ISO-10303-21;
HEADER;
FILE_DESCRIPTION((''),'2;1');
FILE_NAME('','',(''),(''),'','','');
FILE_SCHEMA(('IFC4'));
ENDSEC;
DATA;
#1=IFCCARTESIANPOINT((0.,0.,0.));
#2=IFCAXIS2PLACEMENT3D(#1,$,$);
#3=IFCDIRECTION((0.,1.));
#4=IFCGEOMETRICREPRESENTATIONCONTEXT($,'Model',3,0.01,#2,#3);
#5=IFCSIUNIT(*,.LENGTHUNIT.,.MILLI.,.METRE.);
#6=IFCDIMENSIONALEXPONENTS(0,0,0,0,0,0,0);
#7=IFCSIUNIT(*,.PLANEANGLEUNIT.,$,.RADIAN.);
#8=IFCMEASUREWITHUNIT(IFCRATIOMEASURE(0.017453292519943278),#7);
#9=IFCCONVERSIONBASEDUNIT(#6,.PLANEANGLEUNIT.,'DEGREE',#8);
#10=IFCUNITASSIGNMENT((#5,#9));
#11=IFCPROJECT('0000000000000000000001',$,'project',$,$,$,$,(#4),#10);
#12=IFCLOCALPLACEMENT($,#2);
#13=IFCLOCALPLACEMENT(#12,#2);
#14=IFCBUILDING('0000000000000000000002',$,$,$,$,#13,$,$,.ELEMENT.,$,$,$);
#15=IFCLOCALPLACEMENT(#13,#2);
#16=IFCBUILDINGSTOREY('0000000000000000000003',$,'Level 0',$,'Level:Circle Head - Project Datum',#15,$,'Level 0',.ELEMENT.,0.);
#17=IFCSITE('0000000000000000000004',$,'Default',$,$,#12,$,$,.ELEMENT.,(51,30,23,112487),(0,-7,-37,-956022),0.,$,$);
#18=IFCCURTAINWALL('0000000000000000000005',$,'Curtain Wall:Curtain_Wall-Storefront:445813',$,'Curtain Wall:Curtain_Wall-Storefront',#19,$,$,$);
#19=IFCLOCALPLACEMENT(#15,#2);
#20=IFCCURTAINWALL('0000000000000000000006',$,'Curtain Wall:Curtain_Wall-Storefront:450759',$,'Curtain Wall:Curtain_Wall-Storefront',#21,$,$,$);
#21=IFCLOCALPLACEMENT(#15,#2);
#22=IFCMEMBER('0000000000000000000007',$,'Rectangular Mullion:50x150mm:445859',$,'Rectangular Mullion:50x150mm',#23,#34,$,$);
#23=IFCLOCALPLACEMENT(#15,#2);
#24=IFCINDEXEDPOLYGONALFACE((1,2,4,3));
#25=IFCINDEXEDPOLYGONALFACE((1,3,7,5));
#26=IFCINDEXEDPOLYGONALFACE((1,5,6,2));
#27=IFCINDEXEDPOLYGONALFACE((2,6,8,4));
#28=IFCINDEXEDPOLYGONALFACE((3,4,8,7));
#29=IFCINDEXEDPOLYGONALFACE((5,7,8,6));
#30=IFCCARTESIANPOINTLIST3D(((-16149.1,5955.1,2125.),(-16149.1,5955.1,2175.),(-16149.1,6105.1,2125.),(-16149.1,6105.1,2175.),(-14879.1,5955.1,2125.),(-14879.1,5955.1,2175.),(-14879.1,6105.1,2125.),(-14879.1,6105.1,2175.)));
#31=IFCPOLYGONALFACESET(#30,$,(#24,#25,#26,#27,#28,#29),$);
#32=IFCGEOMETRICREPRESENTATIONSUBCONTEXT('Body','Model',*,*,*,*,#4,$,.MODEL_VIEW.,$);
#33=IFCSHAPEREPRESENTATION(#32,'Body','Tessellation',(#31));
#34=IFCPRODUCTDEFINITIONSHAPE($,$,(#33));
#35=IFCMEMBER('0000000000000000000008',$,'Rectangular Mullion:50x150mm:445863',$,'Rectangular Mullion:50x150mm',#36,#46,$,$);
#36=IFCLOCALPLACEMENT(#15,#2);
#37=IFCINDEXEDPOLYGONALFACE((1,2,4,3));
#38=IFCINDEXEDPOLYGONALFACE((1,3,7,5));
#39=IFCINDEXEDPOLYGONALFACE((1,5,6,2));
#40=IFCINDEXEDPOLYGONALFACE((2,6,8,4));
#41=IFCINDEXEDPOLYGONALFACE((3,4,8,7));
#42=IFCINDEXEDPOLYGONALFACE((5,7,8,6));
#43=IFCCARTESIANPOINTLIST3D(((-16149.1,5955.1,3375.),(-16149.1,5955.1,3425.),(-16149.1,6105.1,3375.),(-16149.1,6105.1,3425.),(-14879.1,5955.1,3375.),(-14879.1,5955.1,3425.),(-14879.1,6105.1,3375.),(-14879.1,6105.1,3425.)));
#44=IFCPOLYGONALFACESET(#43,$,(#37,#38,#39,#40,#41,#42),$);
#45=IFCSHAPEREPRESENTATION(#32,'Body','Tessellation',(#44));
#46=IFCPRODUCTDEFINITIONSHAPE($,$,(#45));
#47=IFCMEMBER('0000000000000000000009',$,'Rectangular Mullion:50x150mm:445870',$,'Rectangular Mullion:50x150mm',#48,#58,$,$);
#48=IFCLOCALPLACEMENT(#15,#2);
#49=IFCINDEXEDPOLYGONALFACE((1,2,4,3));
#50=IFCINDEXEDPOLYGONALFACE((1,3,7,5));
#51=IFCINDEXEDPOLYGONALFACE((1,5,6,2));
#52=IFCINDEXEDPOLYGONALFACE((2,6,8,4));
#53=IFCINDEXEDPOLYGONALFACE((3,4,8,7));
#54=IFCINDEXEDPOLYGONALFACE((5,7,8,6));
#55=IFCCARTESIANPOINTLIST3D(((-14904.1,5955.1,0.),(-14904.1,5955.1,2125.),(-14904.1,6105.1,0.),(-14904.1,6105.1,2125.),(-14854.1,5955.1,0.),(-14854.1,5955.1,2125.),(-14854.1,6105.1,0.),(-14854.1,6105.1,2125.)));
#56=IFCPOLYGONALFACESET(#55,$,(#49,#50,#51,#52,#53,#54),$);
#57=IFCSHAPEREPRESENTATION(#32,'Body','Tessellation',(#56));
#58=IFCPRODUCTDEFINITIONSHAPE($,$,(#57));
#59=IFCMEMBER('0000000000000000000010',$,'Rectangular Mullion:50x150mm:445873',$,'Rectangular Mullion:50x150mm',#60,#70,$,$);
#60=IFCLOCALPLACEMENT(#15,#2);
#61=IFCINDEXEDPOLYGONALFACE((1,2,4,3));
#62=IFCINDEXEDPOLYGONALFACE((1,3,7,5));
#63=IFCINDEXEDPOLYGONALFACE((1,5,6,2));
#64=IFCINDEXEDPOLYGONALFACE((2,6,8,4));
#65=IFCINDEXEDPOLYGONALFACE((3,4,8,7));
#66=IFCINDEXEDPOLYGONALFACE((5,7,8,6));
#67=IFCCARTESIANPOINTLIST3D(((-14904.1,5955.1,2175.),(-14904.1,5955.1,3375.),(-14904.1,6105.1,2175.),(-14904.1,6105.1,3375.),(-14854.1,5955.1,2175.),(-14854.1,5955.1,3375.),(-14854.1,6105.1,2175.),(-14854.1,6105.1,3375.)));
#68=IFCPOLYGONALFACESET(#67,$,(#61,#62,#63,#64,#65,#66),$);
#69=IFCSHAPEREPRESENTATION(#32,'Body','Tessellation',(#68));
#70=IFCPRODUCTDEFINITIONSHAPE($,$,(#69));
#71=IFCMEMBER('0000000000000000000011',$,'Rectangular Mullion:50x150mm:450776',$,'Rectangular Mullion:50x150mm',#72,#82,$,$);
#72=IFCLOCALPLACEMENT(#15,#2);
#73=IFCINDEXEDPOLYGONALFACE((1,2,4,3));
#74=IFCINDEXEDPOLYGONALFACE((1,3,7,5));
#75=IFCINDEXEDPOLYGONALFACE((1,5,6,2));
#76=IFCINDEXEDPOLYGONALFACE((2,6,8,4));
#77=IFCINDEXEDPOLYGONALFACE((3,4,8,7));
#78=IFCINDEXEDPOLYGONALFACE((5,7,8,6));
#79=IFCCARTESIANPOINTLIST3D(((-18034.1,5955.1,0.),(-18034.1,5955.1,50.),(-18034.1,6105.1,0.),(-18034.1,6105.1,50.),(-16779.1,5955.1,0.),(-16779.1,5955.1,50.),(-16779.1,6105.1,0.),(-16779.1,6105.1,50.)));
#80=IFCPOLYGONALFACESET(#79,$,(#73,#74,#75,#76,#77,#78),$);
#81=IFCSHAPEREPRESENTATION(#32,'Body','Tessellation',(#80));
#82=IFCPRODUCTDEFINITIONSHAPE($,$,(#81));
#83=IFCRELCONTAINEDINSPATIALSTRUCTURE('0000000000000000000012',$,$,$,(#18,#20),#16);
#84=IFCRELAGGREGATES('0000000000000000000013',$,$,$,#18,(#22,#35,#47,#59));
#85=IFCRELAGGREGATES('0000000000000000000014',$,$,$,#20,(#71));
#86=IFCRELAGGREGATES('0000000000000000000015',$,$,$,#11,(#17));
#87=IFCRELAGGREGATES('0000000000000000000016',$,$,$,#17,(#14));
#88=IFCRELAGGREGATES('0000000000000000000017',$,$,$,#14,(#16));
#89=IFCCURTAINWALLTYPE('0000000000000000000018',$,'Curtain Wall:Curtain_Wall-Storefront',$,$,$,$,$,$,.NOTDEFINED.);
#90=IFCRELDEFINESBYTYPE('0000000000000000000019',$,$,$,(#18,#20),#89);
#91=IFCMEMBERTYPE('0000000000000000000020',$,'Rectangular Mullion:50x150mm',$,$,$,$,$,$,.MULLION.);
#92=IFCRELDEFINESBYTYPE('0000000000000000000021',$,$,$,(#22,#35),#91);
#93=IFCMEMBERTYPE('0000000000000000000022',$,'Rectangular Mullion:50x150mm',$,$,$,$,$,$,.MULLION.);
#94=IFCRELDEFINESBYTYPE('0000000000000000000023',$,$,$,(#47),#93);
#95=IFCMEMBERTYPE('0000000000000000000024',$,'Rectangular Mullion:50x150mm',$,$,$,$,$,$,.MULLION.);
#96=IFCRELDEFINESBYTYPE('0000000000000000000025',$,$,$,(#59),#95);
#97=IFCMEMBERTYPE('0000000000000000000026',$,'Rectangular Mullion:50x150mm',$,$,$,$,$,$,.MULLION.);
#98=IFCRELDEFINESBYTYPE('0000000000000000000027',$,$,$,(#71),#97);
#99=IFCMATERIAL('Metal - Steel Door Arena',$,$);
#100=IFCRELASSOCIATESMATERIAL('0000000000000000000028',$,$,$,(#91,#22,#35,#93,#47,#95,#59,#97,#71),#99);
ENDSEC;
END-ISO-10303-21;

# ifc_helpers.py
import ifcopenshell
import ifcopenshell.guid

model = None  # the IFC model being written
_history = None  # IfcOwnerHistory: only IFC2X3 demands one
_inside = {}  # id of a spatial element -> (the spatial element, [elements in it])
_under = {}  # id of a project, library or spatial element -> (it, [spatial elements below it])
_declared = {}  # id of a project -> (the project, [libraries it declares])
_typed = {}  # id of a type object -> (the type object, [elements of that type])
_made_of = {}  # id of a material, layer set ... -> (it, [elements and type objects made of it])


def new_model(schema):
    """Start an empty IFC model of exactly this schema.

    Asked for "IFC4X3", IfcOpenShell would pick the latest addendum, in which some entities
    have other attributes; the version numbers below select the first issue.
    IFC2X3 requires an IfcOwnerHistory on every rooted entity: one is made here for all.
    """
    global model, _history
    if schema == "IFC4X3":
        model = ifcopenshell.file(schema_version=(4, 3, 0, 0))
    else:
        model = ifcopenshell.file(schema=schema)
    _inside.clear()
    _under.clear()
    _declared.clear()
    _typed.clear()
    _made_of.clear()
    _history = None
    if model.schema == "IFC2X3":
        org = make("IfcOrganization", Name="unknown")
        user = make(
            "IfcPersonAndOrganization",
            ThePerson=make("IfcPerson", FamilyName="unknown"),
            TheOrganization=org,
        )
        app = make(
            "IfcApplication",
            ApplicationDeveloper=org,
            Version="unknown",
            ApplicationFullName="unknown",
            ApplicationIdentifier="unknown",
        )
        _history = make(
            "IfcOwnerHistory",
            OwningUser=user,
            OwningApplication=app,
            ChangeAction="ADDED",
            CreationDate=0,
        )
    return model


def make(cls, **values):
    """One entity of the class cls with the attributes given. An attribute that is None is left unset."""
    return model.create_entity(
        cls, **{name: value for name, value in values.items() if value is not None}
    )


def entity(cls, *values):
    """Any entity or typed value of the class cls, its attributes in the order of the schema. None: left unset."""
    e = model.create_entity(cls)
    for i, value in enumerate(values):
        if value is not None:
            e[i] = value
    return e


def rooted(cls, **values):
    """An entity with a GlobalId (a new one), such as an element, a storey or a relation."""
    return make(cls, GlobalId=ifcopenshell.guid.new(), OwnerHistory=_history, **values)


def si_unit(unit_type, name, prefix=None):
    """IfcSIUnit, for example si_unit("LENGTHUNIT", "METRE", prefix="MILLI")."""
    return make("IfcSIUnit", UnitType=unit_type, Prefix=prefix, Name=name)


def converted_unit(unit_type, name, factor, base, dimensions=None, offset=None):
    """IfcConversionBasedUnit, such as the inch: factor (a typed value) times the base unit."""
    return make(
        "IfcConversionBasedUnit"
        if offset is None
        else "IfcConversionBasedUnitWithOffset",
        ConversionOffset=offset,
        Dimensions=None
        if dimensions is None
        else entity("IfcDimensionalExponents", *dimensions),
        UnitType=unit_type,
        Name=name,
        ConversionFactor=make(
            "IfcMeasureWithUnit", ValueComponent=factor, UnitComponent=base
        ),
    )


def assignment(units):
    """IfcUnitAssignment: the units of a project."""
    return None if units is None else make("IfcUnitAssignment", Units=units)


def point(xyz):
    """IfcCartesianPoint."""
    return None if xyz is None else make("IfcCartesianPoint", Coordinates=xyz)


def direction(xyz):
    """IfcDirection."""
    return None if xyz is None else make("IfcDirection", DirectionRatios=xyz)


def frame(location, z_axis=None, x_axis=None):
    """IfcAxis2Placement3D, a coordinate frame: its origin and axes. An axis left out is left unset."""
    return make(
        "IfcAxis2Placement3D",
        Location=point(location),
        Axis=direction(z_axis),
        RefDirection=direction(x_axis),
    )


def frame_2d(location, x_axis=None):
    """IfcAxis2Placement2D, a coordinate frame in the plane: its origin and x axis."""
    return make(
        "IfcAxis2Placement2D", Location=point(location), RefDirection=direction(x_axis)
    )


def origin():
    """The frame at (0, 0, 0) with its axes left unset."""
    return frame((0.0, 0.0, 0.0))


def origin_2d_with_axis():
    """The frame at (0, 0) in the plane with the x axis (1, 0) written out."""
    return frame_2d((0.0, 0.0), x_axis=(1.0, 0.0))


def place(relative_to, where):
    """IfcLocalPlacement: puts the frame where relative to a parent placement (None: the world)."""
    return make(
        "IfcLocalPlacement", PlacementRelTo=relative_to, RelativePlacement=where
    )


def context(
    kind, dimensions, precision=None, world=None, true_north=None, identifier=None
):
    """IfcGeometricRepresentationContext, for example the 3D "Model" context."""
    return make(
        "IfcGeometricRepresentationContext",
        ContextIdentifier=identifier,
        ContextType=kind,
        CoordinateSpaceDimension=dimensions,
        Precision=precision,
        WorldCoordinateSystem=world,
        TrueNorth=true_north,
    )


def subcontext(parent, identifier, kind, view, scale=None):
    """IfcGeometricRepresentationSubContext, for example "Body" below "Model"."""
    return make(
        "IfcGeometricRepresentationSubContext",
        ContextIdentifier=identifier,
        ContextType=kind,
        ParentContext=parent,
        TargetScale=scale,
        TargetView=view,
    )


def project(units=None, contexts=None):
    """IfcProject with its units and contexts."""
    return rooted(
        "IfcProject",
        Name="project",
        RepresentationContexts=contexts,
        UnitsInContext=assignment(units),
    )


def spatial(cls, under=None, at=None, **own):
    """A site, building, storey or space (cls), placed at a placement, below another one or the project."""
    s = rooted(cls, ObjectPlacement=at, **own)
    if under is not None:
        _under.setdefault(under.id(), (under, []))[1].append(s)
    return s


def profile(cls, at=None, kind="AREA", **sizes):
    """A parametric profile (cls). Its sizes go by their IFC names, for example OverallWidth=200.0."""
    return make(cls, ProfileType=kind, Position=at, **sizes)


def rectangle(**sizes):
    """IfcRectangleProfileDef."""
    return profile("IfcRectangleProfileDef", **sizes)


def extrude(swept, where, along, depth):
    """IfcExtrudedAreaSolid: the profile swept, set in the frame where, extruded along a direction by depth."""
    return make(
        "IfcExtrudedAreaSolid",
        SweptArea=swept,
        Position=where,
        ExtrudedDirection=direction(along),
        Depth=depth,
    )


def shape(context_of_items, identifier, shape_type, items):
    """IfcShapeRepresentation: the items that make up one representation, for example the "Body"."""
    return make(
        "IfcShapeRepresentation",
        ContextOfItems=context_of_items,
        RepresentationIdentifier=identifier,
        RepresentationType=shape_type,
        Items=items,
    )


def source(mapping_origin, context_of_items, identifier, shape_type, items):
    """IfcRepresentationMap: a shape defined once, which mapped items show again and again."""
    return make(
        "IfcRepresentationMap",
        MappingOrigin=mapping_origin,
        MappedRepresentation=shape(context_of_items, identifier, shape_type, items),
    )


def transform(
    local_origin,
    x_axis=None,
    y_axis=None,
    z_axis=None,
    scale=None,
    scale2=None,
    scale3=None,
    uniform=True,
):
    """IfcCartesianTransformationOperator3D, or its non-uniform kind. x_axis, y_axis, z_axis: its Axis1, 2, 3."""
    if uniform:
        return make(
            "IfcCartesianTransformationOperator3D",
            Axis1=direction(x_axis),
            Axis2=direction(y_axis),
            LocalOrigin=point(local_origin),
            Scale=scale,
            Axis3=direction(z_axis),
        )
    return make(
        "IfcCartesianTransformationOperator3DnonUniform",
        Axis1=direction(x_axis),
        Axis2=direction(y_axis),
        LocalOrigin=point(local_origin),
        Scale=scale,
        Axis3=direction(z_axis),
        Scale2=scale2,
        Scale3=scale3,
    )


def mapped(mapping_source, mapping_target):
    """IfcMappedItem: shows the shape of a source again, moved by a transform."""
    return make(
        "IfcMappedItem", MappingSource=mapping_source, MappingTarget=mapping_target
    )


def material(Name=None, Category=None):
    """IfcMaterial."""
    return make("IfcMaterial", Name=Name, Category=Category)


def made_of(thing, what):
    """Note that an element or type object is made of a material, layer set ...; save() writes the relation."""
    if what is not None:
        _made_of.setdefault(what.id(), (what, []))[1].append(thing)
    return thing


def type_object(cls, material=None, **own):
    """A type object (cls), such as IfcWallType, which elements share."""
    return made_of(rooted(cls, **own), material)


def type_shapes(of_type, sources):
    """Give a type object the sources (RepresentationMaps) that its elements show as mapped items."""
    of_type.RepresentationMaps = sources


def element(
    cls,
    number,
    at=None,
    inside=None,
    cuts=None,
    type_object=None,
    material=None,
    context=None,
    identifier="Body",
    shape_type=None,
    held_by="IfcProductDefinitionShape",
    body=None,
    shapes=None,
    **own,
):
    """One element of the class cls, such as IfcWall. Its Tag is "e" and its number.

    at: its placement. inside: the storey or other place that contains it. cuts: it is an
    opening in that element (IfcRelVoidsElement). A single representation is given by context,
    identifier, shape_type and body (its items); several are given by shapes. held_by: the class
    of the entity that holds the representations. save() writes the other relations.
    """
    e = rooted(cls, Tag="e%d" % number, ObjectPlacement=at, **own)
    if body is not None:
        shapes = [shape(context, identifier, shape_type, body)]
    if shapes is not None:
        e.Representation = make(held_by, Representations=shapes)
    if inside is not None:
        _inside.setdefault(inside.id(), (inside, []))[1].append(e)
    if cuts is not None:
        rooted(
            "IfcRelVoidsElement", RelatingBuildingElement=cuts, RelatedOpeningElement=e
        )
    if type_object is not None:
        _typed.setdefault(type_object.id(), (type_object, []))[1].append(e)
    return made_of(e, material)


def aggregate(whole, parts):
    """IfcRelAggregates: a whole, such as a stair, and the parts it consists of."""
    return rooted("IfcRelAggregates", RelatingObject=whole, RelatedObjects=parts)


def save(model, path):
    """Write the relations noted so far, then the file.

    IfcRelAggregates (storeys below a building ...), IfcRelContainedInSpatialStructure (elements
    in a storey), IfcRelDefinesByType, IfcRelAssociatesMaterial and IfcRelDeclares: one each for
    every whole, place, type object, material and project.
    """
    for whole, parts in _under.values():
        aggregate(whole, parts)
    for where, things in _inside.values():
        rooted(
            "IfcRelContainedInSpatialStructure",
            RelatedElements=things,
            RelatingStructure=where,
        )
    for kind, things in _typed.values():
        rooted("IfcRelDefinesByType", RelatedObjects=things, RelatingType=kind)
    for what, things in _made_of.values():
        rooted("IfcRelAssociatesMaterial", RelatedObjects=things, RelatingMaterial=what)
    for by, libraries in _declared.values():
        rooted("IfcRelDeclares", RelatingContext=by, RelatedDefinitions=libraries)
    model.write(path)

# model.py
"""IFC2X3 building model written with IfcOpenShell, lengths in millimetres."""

from ifc_helpers import new_model, entity, si_unit, converted_unit, direction, frame, origin, origin_2d_with_axis, place, context, subcontext, project, spatial, rectangle, extrude, source, transform, mapped, material, type_object, type_shapes, element, aggregate, save


model = new_model("IFC2X3")

# Units and contexts
model_context = context("Model", 3, precision=0.01, world=origin(), true_north=direction((0.0, 1.0)))
body_context = subcontext(model_context, "Body", "Model", "MODEL_VIEW")
ifc_project = project(units=[si_unit("LENGTHUNIT", "METRE", prefix="MILLI"), converted_unit("PLANEANGLEUNIT", "DEGREE", entity("IfcRatioMeasure", 0.017453292519943278), si_unit("PLANEANGLEUNIT", "RADIAN"), dimensions=[0, 0, 0, 0, 0, 0, 0])], contexts=[model_context])

# Site, building, storey
site_placement = place(None, origin())
site = spatial("IfcSite", under=ifc_project, at=site_placement, Name="Default", CompositionType="ELEMENT", RefLatitude=(51, 30, 23, 112487), RefLongitude=(0, -7, -37, -956022), RefElevation=0.0)
building_placement = place(site_placement, origin())
building = spatial("IfcBuilding", under=site, at=building_placement, CompositionType="ELEMENT")
storey_placement = place(building_placement, origin())
storey = spatial("IfcBuildingStorey", under=building, at=storey_placement, Name="Level 0", ObjectType="Level:Circle Head - Project Datum", LongName="Level 0", CompositionType="ELEMENT", Elevation=0.0)

# Curtain walls
curtain_wall_type = type_object("IfcCurtainWallType", Name="Curtain Wall:Curtain_Wall-Storefront", PredefinedType="NOTDEFINED")
curtain_wall_1_placement = place(storey_placement, origin())
curtain_wall_1 = element("IfcCurtainWall", 1, at=curtain_wall_1_placement, inside=storey, type_object=curtain_wall_type, Name="Curtain Wall:Curtain_Wall-Storefront:445813", ObjectType="Curtain Wall:Curtain_Wall-Storefront")
ifc_material_1 = material(Name="Metal - Steel Door Arena")
curtain_wall_2_placement = place(storey_placement, origin())
curtain_wall_2 = element("IfcCurtainWall", 2, at=curtain_wall_2_placement, inside=storey, type_object=curtain_wall_type, Name="Curtain Wall:Curtain_Wall-Storefront:450759", ObjectType="Curtain Wall:Curtain_Wall-Storefront")

# Members
member_type_1 = type_object("IfcMemberType", Name="Rectangular Mullion:50x150mm", PredefinedType="MULLION", material=ifc_material_1)
shared_shape_1 = source(origin(), body_context, "Body", "SweptSolid", [
    extrude(rectangle(XDim=150.0, YDim=50.0, at=origin_2d_with_axis()), frame((0.0, 0.0, -1270.0), z_axis=(0.0, 0.0, 1.0), x_axis=(0.0, -1.0, 0.0)), (0.0, 0.0, 1.0), 1270.0),
])
type_shapes(member_type_1, [shared_shape_1])
member_1_placement = place(curtain_wall_1_placement, frame((-16149.1, 6030.1, 2150.0), z_axis=(-1.0, 0.0, 0.0), x_axis=(0.0, 0.0, 1.0)))
member_1 = element("IfcMember", 3, at=member_1_placement, type_object=member_type_1, material=ifc_material_1, Name="Rectangular Mullion:50x150mm:445859", ObjectType="Rectangular Mullion:50x150mm", context=body_context, shape_type="MappedRepresentation", body=[
    mapped(shared_shape_1, transform((0.0, 0.0, 0.0), scale=1.0)),
])
member_2_placement = place(curtain_wall_1_placement, frame((-16149.1, 6030.1, 3400.0), z_axis=(-1.0, 0.0, 0.0), x_axis=(0.0, 0.0, 1.0)))
member_2 = element("IfcMember", 4, at=member_2_placement, type_object=member_type_1, material=ifc_material_1, Name="Rectangular Mullion:50x150mm:445863", ObjectType="Rectangular Mullion:50x150mm", context=body_context, shape_type="MappedRepresentation", body=[
    mapped(shared_shape_1, transform((0.0, 0.0, 0.0), scale=1.0)),
])
member_type_2 = type_object("IfcMemberType", Name="Rectangular Mullion:50x150mm", PredefinedType="MULLION", material=ifc_material_1)
shared_shape_2 = source(origin(), body_context, "Body", "SweptSolid", [
    extrude(rectangle(XDim=150.0, YDim=50.0, at=origin_2d_with_axis()), frame((0.0, 0.0, -2125.0), z_axis=(0.0, 0.0, 1.0), x_axis=(0.0, -1.0, 0.0)), (0.0, 0.0, 1.0), 2125.0),
])
type_shapes(member_type_2, [shared_shape_2])
member_3_placement = place(curtain_wall_1_placement, frame((-14879.1, 6030.1, 0.0), z_axis=(0.0, 0.0, -1.0), x_axis=(-1.0, 0.0, 0.0)))
member_3 = element("IfcMember", 5, at=member_3_placement, type_object=member_type_2, material=ifc_material_1, Name="Rectangular Mullion:50x150mm:445870", ObjectType="Rectangular Mullion:50x150mm", context=body_context, shape_type="MappedRepresentation", body=[
    mapped(shared_shape_2, transform((0.0, 0.0, 0.0), scale=1.0)),
])
member_type_3 = type_object("IfcMemberType", Name="Rectangular Mullion:50x150mm", PredefinedType="MULLION", material=ifc_material_1)
shared_shape_3 = source(origin(), body_context, "Body", "SweptSolid", [
    extrude(rectangle(XDim=150.0, YDim=50.0, at=origin_2d_with_axis()), frame((0.0, 0.0, -1200.0), z_axis=(0.0, 0.0, 1.0), x_axis=(0.0, -1.0, 0.0)), (0.0, 0.0, 1.0), 1200.0),
])
type_shapes(member_type_3, [shared_shape_3])
member_4_placement = place(curtain_wall_1_placement, frame((-14879.1, 6030.1, 2175.0), z_axis=(0.0, 0.0, -1.0), x_axis=(-1.0, 0.0, 0.0)))
member_4 = element("IfcMember", 6, at=member_4_placement, type_object=member_type_3, material=ifc_material_1, Name="Rectangular Mullion:50x150mm:445873", ObjectType="Rectangular Mullion:50x150mm", context=body_context, shape_type="MappedRepresentation", body=[
    mapped(shared_shape_3, transform((0.0, 0.0, 0.0), scale=1.0)),
])
member_type_4 = type_object("IfcMemberType", Name="Rectangular Mullion:50x150mm", PredefinedType="MULLION", material=ifc_material_1)
shared_shape_4 = source(origin(), body_context, "Body", "SweptSolid", [
    extrude(rectangle(XDim=150.0, YDim=50.0, at=origin_2d_with_axis()), frame((-25.0, 0.0, -1255.0), z_axis=(0.0, 0.0, 1.0), x_axis=(0.0, -1.0, 0.0)), (0.0, 0.0, 1.0), 1255.0),
])
type_shapes(member_type_4, [shared_shape_4])
member_5_placement = place(curtain_wall_2_placement, frame((-16779.1, 6030.1, 0.0), z_axis=(1.0, 0.0, 0.0), x_axis=(0.0, 0.0, -1.0)))
member_5 = element("IfcMember", 7, at=member_5_placement, type_object=member_type_4, material=ifc_material_1, Name="Rectangular Mullion:50x150mm:450776", ObjectType="Rectangular Mullion:50x150mm", context=body_context, shape_type="MappedRepresentation", body=[
    mapped(shared_shape_4, transform((0.0, 0.0, 0.0), scale=1.0)),
])

aggregate(curtain_wall_1, [member_1, member_2, member_3, member_4])
aggregate(curtain_wall_2, [member_5])

save(model, "model.ifc")
